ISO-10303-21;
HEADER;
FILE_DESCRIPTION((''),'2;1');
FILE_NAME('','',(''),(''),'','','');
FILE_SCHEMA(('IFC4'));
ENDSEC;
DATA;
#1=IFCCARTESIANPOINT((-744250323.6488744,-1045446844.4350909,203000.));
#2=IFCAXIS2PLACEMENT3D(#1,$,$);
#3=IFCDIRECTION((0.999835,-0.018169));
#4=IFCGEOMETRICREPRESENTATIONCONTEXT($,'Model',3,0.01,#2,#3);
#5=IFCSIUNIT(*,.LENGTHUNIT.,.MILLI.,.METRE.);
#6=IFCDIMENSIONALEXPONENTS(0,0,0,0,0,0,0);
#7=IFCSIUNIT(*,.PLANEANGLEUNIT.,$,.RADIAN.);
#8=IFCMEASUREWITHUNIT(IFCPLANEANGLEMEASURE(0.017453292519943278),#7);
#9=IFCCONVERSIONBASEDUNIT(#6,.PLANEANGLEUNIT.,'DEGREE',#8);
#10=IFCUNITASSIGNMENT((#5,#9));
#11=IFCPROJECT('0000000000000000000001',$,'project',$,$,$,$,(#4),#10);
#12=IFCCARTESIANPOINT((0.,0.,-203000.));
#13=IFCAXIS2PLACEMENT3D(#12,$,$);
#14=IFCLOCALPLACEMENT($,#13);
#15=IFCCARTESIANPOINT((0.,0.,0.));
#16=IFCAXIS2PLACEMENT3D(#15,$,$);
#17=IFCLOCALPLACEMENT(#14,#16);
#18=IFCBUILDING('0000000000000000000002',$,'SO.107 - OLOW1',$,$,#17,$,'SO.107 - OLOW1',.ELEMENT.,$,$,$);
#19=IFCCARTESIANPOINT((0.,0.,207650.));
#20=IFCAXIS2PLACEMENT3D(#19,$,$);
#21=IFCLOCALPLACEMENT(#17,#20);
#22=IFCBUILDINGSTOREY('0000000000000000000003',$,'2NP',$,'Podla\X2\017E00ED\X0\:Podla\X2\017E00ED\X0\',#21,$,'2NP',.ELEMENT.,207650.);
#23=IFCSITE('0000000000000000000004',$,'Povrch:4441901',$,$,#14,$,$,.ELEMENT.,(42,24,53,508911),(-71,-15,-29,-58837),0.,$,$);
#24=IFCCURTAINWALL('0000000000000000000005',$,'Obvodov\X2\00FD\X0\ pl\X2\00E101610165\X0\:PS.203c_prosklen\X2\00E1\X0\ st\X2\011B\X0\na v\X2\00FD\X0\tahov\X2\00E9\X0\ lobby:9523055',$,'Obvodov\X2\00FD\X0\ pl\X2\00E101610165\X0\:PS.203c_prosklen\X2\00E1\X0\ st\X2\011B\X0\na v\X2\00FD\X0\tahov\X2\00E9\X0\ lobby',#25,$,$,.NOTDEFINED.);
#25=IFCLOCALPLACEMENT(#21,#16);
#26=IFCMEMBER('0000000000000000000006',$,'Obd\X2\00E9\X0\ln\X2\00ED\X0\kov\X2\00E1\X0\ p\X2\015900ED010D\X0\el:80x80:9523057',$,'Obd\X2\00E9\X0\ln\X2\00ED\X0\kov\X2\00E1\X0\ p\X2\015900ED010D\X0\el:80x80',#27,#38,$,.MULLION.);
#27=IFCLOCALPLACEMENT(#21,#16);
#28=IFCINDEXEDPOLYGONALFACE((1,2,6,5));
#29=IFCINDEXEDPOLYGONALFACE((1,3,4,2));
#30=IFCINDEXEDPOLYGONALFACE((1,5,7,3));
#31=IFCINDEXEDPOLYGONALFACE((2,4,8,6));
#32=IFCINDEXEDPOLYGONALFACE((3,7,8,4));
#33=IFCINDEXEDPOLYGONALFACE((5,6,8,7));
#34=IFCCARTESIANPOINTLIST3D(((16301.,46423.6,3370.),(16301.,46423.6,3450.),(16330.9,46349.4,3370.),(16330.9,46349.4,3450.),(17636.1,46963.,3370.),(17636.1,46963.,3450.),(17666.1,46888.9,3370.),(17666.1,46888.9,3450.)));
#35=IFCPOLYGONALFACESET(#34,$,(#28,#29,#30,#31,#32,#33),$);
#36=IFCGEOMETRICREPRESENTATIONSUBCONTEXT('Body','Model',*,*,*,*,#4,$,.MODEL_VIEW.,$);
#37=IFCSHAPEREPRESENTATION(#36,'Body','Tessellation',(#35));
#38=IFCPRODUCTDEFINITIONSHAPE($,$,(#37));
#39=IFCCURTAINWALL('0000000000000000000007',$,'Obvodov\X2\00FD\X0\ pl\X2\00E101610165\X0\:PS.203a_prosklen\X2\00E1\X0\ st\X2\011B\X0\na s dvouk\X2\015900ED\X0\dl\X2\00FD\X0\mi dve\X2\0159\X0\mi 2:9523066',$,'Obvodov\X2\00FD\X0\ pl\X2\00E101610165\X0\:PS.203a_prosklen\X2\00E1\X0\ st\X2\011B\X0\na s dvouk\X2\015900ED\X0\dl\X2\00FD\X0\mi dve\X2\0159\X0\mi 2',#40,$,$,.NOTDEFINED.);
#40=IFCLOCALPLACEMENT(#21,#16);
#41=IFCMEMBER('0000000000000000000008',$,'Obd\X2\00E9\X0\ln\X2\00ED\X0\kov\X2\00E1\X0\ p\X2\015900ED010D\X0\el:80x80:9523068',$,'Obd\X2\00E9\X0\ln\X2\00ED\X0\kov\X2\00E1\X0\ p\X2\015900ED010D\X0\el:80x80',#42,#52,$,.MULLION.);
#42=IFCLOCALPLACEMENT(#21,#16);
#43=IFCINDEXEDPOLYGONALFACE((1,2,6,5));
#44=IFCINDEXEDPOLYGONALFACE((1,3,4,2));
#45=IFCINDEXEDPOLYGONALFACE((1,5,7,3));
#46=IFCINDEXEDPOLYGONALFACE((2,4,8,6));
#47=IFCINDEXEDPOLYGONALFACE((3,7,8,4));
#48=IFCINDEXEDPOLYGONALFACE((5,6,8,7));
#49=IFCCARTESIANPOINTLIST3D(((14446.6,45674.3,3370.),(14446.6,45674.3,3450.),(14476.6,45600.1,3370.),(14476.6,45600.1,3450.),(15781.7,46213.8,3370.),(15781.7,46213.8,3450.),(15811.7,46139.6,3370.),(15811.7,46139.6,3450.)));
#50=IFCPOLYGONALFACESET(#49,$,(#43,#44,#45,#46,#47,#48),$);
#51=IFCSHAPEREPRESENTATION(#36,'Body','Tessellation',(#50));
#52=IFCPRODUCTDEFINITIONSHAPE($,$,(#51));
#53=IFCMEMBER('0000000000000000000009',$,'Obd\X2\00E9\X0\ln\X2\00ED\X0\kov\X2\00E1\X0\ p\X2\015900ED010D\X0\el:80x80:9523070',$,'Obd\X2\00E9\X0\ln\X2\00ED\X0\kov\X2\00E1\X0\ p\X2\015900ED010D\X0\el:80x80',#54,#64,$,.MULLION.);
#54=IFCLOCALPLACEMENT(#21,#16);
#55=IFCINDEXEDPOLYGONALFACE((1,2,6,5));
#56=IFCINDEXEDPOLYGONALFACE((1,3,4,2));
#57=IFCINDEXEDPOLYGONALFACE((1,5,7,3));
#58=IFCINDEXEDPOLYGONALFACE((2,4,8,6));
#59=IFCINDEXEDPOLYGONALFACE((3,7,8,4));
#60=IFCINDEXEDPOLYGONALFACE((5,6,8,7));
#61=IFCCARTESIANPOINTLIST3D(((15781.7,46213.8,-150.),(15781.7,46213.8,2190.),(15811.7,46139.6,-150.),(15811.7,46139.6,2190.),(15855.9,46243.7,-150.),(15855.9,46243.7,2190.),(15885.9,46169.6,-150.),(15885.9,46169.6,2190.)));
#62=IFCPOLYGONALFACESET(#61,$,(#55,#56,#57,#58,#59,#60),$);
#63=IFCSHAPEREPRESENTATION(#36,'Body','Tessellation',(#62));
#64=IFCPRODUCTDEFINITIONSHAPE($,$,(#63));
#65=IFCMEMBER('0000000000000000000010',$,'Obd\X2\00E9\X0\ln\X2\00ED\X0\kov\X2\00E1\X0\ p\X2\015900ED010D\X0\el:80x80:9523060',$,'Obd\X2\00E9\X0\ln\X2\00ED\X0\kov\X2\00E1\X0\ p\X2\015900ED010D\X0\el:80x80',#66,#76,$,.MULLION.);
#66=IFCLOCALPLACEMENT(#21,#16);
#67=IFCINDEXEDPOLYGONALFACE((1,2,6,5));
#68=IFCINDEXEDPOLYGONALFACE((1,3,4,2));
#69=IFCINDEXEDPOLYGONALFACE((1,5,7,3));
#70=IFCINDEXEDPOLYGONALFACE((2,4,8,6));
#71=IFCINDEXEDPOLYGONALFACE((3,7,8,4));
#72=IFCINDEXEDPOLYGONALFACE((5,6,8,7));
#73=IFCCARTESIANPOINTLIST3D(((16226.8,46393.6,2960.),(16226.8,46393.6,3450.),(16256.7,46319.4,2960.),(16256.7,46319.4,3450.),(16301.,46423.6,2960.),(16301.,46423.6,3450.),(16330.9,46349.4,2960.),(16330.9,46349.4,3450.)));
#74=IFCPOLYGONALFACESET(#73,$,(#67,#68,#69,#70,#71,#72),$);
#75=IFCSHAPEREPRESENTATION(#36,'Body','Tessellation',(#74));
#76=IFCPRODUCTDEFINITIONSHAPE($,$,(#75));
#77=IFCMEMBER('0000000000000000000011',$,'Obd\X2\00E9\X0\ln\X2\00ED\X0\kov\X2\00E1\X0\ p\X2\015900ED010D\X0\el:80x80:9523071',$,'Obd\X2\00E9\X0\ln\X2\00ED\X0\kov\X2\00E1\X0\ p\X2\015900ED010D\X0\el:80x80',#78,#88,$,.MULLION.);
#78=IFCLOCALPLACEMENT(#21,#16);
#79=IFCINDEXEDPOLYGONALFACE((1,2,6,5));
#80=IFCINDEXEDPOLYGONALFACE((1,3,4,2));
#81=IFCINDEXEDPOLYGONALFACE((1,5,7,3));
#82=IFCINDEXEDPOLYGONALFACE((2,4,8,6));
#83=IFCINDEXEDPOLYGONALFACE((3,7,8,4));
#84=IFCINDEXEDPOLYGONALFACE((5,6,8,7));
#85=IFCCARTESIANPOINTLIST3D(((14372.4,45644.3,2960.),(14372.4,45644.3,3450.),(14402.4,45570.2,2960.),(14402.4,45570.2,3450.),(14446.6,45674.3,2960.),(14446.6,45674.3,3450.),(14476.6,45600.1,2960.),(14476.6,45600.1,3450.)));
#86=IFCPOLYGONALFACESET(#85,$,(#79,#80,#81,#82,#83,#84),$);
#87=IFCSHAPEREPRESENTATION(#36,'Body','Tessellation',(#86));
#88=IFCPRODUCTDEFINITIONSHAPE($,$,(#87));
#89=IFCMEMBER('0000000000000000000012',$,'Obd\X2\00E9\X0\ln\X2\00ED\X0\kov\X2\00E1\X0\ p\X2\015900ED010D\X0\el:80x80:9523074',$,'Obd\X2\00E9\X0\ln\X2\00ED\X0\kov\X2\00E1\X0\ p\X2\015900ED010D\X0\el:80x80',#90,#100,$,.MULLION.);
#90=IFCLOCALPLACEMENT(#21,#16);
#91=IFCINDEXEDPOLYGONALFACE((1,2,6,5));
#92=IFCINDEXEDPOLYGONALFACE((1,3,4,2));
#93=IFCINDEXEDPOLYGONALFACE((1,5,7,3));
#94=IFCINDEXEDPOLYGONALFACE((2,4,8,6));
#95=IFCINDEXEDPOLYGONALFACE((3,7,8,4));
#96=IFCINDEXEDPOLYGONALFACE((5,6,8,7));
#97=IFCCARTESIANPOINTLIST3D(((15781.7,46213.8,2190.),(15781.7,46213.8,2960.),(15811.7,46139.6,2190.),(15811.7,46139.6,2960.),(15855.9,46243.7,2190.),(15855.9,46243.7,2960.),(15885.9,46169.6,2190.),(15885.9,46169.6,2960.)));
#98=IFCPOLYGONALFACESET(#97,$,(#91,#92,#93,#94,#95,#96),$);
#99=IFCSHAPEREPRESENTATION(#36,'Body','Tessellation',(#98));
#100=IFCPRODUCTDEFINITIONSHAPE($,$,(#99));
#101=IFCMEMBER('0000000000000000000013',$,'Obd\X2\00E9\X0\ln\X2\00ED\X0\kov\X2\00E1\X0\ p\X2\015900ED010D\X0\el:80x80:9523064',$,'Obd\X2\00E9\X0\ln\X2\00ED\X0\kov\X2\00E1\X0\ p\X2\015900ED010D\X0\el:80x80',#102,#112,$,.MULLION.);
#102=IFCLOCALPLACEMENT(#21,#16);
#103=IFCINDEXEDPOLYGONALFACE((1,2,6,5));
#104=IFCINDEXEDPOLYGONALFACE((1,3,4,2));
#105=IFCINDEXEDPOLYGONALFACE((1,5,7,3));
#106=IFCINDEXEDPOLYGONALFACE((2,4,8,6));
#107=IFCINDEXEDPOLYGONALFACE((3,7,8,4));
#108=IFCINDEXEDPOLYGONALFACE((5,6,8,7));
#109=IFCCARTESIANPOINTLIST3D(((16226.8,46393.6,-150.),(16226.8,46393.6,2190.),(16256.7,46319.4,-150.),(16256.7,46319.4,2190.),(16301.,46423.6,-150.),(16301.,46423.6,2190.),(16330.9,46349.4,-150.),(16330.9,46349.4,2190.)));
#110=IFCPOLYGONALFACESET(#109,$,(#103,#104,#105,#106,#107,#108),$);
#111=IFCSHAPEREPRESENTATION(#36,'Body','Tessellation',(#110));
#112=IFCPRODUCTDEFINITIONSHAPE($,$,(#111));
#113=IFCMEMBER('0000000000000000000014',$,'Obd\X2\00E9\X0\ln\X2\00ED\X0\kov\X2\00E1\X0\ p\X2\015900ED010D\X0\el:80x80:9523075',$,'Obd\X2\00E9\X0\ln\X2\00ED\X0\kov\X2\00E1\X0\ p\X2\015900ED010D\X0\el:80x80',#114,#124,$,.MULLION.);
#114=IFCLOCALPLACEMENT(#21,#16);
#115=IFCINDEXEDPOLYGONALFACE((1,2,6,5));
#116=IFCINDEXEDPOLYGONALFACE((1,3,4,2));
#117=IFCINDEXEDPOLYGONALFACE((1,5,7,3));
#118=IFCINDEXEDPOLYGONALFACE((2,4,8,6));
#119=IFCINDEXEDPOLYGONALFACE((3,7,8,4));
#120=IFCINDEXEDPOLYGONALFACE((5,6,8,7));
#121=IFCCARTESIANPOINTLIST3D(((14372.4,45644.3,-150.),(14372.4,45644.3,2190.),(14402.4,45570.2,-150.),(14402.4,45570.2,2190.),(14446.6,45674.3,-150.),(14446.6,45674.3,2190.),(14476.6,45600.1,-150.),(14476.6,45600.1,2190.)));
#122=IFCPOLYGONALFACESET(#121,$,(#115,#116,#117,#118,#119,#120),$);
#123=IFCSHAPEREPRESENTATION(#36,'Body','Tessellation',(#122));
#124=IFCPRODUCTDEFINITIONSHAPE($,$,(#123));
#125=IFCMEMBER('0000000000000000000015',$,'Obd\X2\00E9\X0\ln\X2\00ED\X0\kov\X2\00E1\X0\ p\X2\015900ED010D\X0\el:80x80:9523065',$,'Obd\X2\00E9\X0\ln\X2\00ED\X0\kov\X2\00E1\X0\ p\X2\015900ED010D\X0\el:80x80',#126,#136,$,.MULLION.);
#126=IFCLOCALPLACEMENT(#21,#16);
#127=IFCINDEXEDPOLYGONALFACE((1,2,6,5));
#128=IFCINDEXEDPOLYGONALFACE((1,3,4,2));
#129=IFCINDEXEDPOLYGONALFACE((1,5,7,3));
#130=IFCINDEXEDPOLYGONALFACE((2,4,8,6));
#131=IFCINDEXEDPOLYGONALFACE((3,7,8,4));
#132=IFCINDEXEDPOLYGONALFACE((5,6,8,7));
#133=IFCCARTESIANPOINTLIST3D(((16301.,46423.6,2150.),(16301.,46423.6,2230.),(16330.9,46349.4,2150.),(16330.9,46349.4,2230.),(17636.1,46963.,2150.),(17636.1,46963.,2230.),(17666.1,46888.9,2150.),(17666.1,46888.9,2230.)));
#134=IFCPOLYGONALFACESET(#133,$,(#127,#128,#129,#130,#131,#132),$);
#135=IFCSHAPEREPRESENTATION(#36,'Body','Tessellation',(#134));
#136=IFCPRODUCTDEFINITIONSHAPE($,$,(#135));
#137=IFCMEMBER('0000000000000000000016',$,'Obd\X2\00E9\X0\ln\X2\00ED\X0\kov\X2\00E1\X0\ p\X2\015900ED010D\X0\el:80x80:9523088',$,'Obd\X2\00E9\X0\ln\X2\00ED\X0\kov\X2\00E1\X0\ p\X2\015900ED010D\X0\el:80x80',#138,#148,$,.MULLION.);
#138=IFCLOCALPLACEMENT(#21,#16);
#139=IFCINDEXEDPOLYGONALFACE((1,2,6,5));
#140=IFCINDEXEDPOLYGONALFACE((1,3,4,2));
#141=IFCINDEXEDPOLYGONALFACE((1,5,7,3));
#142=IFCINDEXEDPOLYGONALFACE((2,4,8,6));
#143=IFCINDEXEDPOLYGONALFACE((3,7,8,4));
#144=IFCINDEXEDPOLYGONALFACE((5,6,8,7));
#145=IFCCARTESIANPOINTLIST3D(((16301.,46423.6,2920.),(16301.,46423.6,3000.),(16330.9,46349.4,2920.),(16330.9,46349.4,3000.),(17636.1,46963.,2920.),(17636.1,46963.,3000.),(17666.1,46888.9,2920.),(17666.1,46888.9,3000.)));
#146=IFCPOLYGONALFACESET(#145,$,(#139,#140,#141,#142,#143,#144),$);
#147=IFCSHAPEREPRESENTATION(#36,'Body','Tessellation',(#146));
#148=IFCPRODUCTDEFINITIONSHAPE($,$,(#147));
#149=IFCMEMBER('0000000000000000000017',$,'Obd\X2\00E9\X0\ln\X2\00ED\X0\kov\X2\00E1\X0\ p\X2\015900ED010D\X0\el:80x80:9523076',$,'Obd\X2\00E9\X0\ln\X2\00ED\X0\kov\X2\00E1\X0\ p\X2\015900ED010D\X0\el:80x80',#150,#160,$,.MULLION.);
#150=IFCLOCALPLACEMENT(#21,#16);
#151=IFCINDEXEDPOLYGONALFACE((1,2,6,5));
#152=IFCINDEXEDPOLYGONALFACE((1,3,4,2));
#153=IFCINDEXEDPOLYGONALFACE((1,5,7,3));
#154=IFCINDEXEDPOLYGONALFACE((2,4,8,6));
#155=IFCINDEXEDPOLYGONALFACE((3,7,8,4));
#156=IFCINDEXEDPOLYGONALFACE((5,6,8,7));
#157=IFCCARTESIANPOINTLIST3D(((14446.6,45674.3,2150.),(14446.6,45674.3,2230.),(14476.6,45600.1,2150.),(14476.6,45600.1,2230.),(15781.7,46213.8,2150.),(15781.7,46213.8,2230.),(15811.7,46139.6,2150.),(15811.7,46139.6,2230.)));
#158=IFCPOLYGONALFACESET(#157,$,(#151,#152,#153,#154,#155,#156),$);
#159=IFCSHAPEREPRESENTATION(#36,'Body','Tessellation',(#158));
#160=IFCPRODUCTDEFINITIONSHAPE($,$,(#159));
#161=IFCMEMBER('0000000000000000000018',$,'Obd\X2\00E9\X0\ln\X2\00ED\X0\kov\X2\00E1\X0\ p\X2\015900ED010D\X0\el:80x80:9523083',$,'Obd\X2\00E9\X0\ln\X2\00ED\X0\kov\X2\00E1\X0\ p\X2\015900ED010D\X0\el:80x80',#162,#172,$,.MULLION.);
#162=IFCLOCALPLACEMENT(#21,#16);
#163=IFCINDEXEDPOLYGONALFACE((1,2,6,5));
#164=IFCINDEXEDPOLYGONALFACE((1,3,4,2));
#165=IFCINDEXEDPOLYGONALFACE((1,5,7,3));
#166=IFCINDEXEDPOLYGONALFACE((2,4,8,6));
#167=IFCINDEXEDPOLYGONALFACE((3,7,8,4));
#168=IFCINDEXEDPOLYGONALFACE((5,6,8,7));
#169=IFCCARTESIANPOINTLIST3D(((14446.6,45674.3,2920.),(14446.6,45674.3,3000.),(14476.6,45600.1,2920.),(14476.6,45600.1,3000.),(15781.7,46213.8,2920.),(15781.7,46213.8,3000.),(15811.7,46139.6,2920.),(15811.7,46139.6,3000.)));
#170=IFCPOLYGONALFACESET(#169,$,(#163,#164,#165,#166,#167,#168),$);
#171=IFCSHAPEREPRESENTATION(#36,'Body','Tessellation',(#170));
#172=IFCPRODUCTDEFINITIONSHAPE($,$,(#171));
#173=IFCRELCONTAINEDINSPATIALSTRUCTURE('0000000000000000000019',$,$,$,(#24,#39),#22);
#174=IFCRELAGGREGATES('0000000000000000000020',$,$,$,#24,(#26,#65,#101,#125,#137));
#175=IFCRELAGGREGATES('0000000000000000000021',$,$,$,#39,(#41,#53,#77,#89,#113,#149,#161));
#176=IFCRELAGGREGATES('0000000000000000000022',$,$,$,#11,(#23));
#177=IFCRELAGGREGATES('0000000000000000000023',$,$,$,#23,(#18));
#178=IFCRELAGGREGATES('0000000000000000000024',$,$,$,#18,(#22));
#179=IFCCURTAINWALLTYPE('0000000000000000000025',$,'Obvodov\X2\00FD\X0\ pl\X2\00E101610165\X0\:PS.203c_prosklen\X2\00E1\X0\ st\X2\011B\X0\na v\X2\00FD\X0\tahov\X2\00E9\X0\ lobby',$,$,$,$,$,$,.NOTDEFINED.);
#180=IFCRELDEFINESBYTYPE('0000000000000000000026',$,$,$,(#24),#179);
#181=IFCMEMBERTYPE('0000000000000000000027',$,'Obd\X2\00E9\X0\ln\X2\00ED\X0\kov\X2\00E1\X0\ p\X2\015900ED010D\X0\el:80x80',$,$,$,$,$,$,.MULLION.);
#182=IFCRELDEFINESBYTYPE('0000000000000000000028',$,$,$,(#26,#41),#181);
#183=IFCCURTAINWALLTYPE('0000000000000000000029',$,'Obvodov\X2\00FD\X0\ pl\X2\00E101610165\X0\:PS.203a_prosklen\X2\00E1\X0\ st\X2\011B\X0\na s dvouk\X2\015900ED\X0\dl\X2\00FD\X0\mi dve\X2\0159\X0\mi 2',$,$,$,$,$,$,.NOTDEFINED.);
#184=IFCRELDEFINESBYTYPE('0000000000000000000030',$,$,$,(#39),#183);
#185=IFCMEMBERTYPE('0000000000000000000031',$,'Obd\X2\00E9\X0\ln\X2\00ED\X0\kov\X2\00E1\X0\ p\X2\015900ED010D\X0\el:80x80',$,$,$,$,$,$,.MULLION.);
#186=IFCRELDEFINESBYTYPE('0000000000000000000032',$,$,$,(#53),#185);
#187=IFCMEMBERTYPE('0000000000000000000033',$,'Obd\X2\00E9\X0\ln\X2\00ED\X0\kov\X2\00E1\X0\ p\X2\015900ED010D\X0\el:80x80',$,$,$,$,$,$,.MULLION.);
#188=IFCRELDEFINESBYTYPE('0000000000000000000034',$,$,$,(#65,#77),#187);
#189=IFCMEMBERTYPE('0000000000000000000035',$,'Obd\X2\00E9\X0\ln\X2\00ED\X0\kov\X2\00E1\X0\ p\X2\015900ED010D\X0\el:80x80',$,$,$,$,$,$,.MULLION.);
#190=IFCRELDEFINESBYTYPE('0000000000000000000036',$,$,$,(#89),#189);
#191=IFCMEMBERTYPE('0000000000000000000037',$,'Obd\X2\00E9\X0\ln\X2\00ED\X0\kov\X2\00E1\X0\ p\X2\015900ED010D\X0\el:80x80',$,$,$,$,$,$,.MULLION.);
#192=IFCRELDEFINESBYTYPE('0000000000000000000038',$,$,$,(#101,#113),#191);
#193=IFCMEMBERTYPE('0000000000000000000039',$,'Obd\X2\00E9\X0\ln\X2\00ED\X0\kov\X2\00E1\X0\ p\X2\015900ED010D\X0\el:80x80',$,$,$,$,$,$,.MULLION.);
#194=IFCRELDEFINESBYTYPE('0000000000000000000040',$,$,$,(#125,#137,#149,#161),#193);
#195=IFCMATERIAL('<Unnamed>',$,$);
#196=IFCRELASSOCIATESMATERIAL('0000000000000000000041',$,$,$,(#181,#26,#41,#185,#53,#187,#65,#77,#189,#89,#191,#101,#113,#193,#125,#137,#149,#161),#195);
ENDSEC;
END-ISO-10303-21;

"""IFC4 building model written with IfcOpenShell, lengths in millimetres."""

from ifc_helpers import new_model, entity, si_unit, converted_unit, direction, frame, origin, place, context, subcontext, project, spatial, indexed_curve, outline, extrude, source, transform, mapped, material, type_object, type_shapes, element, aggregate, save


model = new_model("IFC4")

# Units and contexts
model_context = context("Model", 3, precision=0.01, world=frame((-744250323.6488744, -1045446844.4350909, 203000.0)), true_north=direction((0.999835, -0.018169)))
body_context = subcontext(model_context, "Body", "Model", "MODEL_VIEW")
ifc_project = project(units=[si_unit("LENGTHUNIT", "METRE", prefix="MILLI"), converted_unit("PLANEANGLEUNIT", "DEGREE", entity("IfcPlaneAngleMeasure", 0.017453292519943278), si_unit("PLANEANGLEUNIT", "RADIAN"), dimensions=[0, 0, 0, 0, 0, 0, 0])], contexts=[model_context])

# Site, building, storey
site_placement = place(None, frame((0.0, 0.0, -203000.0)))
site = spatial("IfcSite", under=ifc_project, at=site_placement, Name="Povrch:4441901", CompositionType="ELEMENT", RefLatitude=(42, 24, 53, 508911), RefLongitude=(-71, -15, -29, -58837), RefElevation=0.0)
building_placement = place(site_placement, origin())
building = spatial("IfcBuilding", under=site, at=building_placement, Name="SO.107 - OLOW1", LongName="SO.107 - OLOW1", CompositionType="ELEMENT")
storey_placement = place(building_placement, frame((0.0, 0.0, 207650.0)))
storey = spatial("IfcBuildingStorey", under=building, at=storey_placement, Name="2NP", ObjectType="Podlaží:Podlaží", LongName="2NP", CompositionType="ELEMENT", Elevation=207650.0)

# Curtain wall, member
curtain_wall_type_1 = type_object("IfcCurtainWallType", Name="Obvodový plášť:PS.203c_prosklená stěna výtahové lobby", PredefinedType="NOTDEFINED")
curtain_wall_1_placement = place(storey_placement, frame((0.0, 0.0, -207650.0)))
curtain_wall_1 = element("IfcCurtainWall", 1, at=curtain_wall_1_placement, inside=storey, type_object=curtain_wall_type_1, Name="Obvodový plášť:PS.203c_prosklená stěna výtahové lobby:9523055", ObjectType="Obvodový plášť:PS.203c_prosklená stěna výtahové lobby", PredefinedType="NOTDEFINED")
ifc_material_1 = material(Name="<Unnamed>")
member_type_1 = type_object("IfcMemberType", Name="Obdélníková příčel:80x80", PredefinedType="MULLION", material=ifc_material_1)
shared_shape_1 = source(origin(), body_context, "Body", "SweptSolid", [
    extrude(outline(indexed_curve([(-40.0, -40.0), (40.0, -40.0), (40.0, 40.0), (-40.0, 40.0), (-40.0, -40.0)], self_intersect=False)), frame((-40.0, 0.0, -1440.0), z_axis=(0.0, 0.0, 1.0), x_axis=(-1.0, 0.0, 0.0)), (0.0, 0.0, 1.0), 1440.0),
])
type_shapes(member_type_1, [shared_shape_1])
member_1_placement = place(curtain_wall_1_placement, frame((17651.1, 46925.9, 211100.0), z_axis=(0.927176, 0.374626, 0.0), x_axis=(0.0, 0.0, 1.0)))
member_1 = element("IfcMember", 2, at=member_1_placement, type_object=member_type_1, material=ifc_material_1, Name="Obdélníková příčel:80x80:9523057", ObjectType="Obdélníková příčel:80x80", PredefinedType="MULLION", context=body_context, shape_type="MappedRepresentation", body=[
    mapped(shared_shape_1, transform((0.0, 0.0, 0.0), scale=1.0)),
])

# Curtain wall, members
curtain_wall_type_2 = type_object("IfcCurtainWallType", Name="Obvodový plášť:PS.203a_prosklená stěna s dvoukřídlými dveřmi 2", PredefinedType="NOTDEFINED")
curtain_wall_2_placement = place(storey_placement, frame((0.0, 0.0, -207650.0)))
curtain_wall_2 = element("IfcCurtainWall", 3, at=curtain_wall_2_placement, inside=storey, type_object=curtain_wall_type_2, Name="Obvodový plášť:PS.203a_prosklená stěna s dvoukřídlými dveřmi 2:9523066", ObjectType="Obvodový plášť:PS.203a_prosklená stěna s dvoukřídlými dveřmi 2", PredefinedType="NOTDEFINED")
member_2_placement = place(curtain_wall_2_placement, frame((15796.7, 46176.7, 211100.0), z_axis=(0.927176, 0.374626, 0.0), x_axis=(0.0, 0.0, 1.0)))
member_2 = element("IfcMember", 4, at=member_2_placement, type_object=member_type_1, material=ifc_material_1, Name="Obdélníková příčel:80x80:9523068", ObjectType="Obdélníková příčel:80x80", PredefinedType="MULLION", context=body_context, shape_type="MappedRepresentation", body=[
    mapped(shared_shape_1, transform((0.0, 0.0, 0.0), scale=1.0)),
])
member_type_2 = type_object("IfcMemberType", Name="Obdélníková příčel:80x80", PredefinedType="MULLION", material=ifc_material_1)
shared_shape_2 = source(origin(), body_context, "Body", "SweptSolid", [
    extrude(outline(indexed_curve([(-40.0, -40.0), (40.0, -40.0), (40.0, 40.0), (-40.0, 40.0), (-40.0, -40.0)], self_intersect=False)), frame((-40.0, 0.0, -2340.0), z_axis=(0.0, 0.0, 1.0), x_axis=(-1.0, 0.0, 0.0)), (0.0, 0.0, 1.0), 2340.0),
])
type_shapes(member_type_2, [shared_shape_2])
member_3_placement = place(curtain_wall_2_placement, frame((15870.9, 46206.7, 207500.0), z_axis=(0.0, 0.0, -1.0), x_axis=(0.927176, 0.374626, 0.0)))
member_3 = element("IfcMember", 5, at=member_3_placement, type_object=member_type_2, material=ifc_material_1, Name="Obdélníková příčel:80x80:9523070", ObjectType="Obdélníková příčel:80x80", PredefinedType="MULLION", context=body_context, shape_type="MappedRepresentation", body=[
    mapped(shared_shape_2, transform((0.0, 0.0, 0.0), scale=1.0)),
])

# Members
member_type_3 = type_object("IfcMemberType", Name="Obdélníková příčel:80x80", PredefinedType="MULLION", material=ifc_material_1)
shared_shape_3 = source(origin(), body_context, "Body", "SweptSolid", [
    extrude(outline(indexed_curve([(-40.0, -40.0), (40.0, -40.0), (40.0, 40.0), (-40.0, 40.0), (-40.0, -40.0)], self_intersect=False)), frame((-40.0, 0.0, -490.0), z_axis=(0.0, 0.0, 1.0), x_axis=(-1.0, 0.0, 0.0)), (0.0, 0.0, 1.0), 490.0),
])
type_shapes(member_type_3, [shared_shape_3])
member_4_placement = place(curtain_wall_1_placement, frame((16241.8, 46356.5, 211100.0), z_axis=(0.0, 0.0, 1.0), x_axis=(-0.927176, -0.374626, 0.0)))
member_4 = element("IfcMember", 6, at=member_4_placement, type_object=member_type_3, material=ifc_material_1, Name="Obdélníková příčel:80x80:9523060", ObjectType="Obdélníková příčel:80x80", PredefinedType="MULLION", context=body_context, shape_type="MappedRepresentation", body=[
    mapped(shared_shape_3, transform((0.0, 0.0, 0.0), scale=1.0)),
])
member_5_placement = place(curtain_wall_2_placement, frame((14387.4, 45607.3, 211100.0), z_axis=(0.0, 0.0, 1.0), x_axis=(-0.927176, -0.374626, 0.0)))
member_5 = element("IfcMember", 7, at=member_5_placement, type_object=member_type_3, material=ifc_material_1, Name="Obdélníková příčel:80x80:9523071", ObjectType="Obdélníková příčel:80x80", PredefinedType="MULLION", context=body_context, shape_type="MappedRepresentation", body=[
    mapped(shared_shape_3, transform((0.0, 0.0, 0.0), scale=1.0)),
])
member_type_4 = type_object("IfcMemberType", Name="Obdélníková příčel:80x80", PredefinedType="MULLION", material=ifc_material_1)
shared_shape_4 = source(origin(), body_context, "Body", "SweptSolid", [
    extrude(outline(indexed_curve([(-40.0, -40.0), (40.0, -40.0), (40.0, 40.0), (-40.0, 40.0), (-40.0, -40.0)], self_intersect=False)), frame((-40.0, 0.0, -770.0), z_axis=(0.0, 0.0, 1.0), x_axis=(-1.0, 0.0, 0.0)), (0.0, 0.0, 1.0), 770.0),
])
type_shapes(member_type_4, [shared_shape_4])
member_6_placement = place(curtain_wall_2_placement, frame((15870.9, 46206.7, 209840.0), z_axis=(0.0, 0.0, -1.0), x_axis=(0.927176, 0.374626, 0.0)))
member_6 = element("IfcMember", 8, at=member_6_placement, type_object=member_type_4, material=ifc_material_1, Name="Obdélníková příčel:80x80:9523074", ObjectType="Obdélníková příčel:80x80", PredefinedType="MULLION", context=body_context, shape_type="MappedRepresentation", body=[
    mapped(shared_shape_4, transform((0.0, 0.0, 0.0), scale=1.0)),
])
member_type_5 = type_object("IfcMemberType", Name="Obdélníková příčel:80x80", PredefinedType="MULLION", material=ifc_material_1)
shared_shape_5 = source(origin(), body_context, "Body", "SweptSolid", [
    extrude(outline(indexed_curve([(-40.0, -40.0), (40.0, -40.0), (40.0, 40.0), (-40.0, 40.0), (-40.0, -40.0)], self_intersect=False)), frame((-40.0, 0.0, -2340.0), z_axis=(0.0, 0.0, 1.0), x_axis=(-1.0, 0.0, 0.0)), (0.0, 0.0, 1.0), 2340.0),
])
type_shapes(member_type_5, [shared_shape_5])
member_7_placement = place(curtain_wall_1_placement, frame((16241.8, 46356.5, 209840.0), z_axis=(0.0, 0.0, 1.0), x_axis=(-0.927176, -0.374626, 0.0)))
member_7 = element("IfcMember", 9, at=member_7_placement, type_object=member_type_5, material=ifc_material_1, Name="Obdélníková příčel:80x80:9523064", ObjectType="Obdélníková příčel:80x80", PredefinedType="MULLION", context=body_context, shape_type="MappedRepresentation", body=[
    mapped(shared_shape_5, transform((0.0, 0.0, 0.0), scale=1.0)),
])
member_8_placement = place(curtain_wall_2_placement, frame((14387.4, 45607.3, 209840.0), z_axis=(0.0, 0.0, 1.0), x_axis=(-0.927176, -0.374626, 0.0)))
member_8 = element("IfcMember", 10, at=member_8_placement, type_object=member_type_5, material=ifc_material_1, Name="Obdélníková příčel:80x80:9523075", ObjectType="Obdélníková příčel:80x80", PredefinedType="MULLION", context=body_context, shape_type="MappedRepresentation", body=[
    mapped(shared_shape_5, transform((0.0, 0.0, 0.0), scale=1.0)),
])
member_type_6 = type_object("IfcMemberType", Name="Obdélníková příčel:80x80", PredefinedType="MULLION", material=ifc_material_1)
shared_shape_6 = source(origin(), body_context, "Body", "SweptSolid", [
    extrude(outline(indexed_curve([(-40.0, -40.0), (40.0, -40.0), (40.0, 40.0), (-40.0, 40.0), (-40.0, -40.0)], self_intersect=False)), frame((0.0, 0.0, -1440.0), z_axis=(0.0, 0.0, 1.0), x_axis=(-1.0, 0.0, 0.0)), (0.0, 0.0, 1.0), 1440.0),
])
type_shapes(member_type_6, [shared_shape_6])
member_9_placement = place(curtain_wall_1_placement, frame((17651.1, 46925.9, 209840.0), z_axis=(0.927176, 0.374626, 0.0), x_axis=(0.0, 0.0, 1.0)))
member_9 = element("IfcMember", 11, at=member_9_placement, type_object=member_type_6, material=ifc_material_1, Name="Obdélníková příčel:80x80:9523065", ObjectType="Obdélníková příčel:80x80", PredefinedType="MULLION", context=body_context, shape_type="MappedRepresentation", body=[
    mapped(shared_shape_6, transform((0.0, 0.0, 0.0), scale=1.0)),
])
member_10_placement = place(curtain_wall_1_placement, frame((17651.1, 46925.9, 210610.0), z_axis=(0.927176, 0.374626, 0.0), x_axis=(0.0, 0.0, 1.0)))
member_10 = element("IfcMember", 12, at=member_10_placement, type_object=member_type_6, material=ifc_material_1, Name="Obdélníková příčel:80x80:9523088", ObjectType="Obdélníková příčel:80x80", PredefinedType="MULLION", context=body_context, shape_type="MappedRepresentation", body=[
    mapped(shared_shape_6, transform((0.0, 0.0, 0.0), scale=1.0)),
])
member_11_placement = place(curtain_wall_2_placement, frame((15796.7, 46176.7, 209840.0), z_axis=(0.927176, 0.374626, 0.0), x_axis=(0.0, 0.0, 1.0)))
member_11 = element("IfcMember", 13, at=member_11_placement, type_object=member_type_6, material=ifc_material_1, Name="Obdélníková příčel:80x80:9523076", ObjectType="Obdélníková příčel:80x80", PredefinedType="MULLION", context=body_context, shape_type="MappedRepresentation", body=[
    mapped(shared_shape_6, transform((0.0, 0.0, 0.0), scale=1.0)),
])
member_12_placement = place(curtain_wall_2_placement, frame((15796.7, 46176.7, 210610.0), z_axis=(0.927176, 0.374626, 0.0), x_axis=(0.0, 0.0, 1.0)))
member_12 = element("IfcMember", 14, at=member_12_placement, type_object=member_type_6, material=ifc_material_1, Name="Obdélníková příčel:80x80:9523083", ObjectType="Obdélníková příčel:80x80", PredefinedType="MULLION", context=body_context, shape_type="MappedRepresentation", body=[
    mapped(shared_shape_6, transform((0.0, 0.0, 0.0), scale=1.0)),
])

aggregate(curtain_wall_1, [member_1, member_4, member_7, member_9, member_10])

aggregate(curtain_wall_2, [member_2, member_3, member_5, member_6, member_8, member_11, member_12])

save(model, "model.ifc")
